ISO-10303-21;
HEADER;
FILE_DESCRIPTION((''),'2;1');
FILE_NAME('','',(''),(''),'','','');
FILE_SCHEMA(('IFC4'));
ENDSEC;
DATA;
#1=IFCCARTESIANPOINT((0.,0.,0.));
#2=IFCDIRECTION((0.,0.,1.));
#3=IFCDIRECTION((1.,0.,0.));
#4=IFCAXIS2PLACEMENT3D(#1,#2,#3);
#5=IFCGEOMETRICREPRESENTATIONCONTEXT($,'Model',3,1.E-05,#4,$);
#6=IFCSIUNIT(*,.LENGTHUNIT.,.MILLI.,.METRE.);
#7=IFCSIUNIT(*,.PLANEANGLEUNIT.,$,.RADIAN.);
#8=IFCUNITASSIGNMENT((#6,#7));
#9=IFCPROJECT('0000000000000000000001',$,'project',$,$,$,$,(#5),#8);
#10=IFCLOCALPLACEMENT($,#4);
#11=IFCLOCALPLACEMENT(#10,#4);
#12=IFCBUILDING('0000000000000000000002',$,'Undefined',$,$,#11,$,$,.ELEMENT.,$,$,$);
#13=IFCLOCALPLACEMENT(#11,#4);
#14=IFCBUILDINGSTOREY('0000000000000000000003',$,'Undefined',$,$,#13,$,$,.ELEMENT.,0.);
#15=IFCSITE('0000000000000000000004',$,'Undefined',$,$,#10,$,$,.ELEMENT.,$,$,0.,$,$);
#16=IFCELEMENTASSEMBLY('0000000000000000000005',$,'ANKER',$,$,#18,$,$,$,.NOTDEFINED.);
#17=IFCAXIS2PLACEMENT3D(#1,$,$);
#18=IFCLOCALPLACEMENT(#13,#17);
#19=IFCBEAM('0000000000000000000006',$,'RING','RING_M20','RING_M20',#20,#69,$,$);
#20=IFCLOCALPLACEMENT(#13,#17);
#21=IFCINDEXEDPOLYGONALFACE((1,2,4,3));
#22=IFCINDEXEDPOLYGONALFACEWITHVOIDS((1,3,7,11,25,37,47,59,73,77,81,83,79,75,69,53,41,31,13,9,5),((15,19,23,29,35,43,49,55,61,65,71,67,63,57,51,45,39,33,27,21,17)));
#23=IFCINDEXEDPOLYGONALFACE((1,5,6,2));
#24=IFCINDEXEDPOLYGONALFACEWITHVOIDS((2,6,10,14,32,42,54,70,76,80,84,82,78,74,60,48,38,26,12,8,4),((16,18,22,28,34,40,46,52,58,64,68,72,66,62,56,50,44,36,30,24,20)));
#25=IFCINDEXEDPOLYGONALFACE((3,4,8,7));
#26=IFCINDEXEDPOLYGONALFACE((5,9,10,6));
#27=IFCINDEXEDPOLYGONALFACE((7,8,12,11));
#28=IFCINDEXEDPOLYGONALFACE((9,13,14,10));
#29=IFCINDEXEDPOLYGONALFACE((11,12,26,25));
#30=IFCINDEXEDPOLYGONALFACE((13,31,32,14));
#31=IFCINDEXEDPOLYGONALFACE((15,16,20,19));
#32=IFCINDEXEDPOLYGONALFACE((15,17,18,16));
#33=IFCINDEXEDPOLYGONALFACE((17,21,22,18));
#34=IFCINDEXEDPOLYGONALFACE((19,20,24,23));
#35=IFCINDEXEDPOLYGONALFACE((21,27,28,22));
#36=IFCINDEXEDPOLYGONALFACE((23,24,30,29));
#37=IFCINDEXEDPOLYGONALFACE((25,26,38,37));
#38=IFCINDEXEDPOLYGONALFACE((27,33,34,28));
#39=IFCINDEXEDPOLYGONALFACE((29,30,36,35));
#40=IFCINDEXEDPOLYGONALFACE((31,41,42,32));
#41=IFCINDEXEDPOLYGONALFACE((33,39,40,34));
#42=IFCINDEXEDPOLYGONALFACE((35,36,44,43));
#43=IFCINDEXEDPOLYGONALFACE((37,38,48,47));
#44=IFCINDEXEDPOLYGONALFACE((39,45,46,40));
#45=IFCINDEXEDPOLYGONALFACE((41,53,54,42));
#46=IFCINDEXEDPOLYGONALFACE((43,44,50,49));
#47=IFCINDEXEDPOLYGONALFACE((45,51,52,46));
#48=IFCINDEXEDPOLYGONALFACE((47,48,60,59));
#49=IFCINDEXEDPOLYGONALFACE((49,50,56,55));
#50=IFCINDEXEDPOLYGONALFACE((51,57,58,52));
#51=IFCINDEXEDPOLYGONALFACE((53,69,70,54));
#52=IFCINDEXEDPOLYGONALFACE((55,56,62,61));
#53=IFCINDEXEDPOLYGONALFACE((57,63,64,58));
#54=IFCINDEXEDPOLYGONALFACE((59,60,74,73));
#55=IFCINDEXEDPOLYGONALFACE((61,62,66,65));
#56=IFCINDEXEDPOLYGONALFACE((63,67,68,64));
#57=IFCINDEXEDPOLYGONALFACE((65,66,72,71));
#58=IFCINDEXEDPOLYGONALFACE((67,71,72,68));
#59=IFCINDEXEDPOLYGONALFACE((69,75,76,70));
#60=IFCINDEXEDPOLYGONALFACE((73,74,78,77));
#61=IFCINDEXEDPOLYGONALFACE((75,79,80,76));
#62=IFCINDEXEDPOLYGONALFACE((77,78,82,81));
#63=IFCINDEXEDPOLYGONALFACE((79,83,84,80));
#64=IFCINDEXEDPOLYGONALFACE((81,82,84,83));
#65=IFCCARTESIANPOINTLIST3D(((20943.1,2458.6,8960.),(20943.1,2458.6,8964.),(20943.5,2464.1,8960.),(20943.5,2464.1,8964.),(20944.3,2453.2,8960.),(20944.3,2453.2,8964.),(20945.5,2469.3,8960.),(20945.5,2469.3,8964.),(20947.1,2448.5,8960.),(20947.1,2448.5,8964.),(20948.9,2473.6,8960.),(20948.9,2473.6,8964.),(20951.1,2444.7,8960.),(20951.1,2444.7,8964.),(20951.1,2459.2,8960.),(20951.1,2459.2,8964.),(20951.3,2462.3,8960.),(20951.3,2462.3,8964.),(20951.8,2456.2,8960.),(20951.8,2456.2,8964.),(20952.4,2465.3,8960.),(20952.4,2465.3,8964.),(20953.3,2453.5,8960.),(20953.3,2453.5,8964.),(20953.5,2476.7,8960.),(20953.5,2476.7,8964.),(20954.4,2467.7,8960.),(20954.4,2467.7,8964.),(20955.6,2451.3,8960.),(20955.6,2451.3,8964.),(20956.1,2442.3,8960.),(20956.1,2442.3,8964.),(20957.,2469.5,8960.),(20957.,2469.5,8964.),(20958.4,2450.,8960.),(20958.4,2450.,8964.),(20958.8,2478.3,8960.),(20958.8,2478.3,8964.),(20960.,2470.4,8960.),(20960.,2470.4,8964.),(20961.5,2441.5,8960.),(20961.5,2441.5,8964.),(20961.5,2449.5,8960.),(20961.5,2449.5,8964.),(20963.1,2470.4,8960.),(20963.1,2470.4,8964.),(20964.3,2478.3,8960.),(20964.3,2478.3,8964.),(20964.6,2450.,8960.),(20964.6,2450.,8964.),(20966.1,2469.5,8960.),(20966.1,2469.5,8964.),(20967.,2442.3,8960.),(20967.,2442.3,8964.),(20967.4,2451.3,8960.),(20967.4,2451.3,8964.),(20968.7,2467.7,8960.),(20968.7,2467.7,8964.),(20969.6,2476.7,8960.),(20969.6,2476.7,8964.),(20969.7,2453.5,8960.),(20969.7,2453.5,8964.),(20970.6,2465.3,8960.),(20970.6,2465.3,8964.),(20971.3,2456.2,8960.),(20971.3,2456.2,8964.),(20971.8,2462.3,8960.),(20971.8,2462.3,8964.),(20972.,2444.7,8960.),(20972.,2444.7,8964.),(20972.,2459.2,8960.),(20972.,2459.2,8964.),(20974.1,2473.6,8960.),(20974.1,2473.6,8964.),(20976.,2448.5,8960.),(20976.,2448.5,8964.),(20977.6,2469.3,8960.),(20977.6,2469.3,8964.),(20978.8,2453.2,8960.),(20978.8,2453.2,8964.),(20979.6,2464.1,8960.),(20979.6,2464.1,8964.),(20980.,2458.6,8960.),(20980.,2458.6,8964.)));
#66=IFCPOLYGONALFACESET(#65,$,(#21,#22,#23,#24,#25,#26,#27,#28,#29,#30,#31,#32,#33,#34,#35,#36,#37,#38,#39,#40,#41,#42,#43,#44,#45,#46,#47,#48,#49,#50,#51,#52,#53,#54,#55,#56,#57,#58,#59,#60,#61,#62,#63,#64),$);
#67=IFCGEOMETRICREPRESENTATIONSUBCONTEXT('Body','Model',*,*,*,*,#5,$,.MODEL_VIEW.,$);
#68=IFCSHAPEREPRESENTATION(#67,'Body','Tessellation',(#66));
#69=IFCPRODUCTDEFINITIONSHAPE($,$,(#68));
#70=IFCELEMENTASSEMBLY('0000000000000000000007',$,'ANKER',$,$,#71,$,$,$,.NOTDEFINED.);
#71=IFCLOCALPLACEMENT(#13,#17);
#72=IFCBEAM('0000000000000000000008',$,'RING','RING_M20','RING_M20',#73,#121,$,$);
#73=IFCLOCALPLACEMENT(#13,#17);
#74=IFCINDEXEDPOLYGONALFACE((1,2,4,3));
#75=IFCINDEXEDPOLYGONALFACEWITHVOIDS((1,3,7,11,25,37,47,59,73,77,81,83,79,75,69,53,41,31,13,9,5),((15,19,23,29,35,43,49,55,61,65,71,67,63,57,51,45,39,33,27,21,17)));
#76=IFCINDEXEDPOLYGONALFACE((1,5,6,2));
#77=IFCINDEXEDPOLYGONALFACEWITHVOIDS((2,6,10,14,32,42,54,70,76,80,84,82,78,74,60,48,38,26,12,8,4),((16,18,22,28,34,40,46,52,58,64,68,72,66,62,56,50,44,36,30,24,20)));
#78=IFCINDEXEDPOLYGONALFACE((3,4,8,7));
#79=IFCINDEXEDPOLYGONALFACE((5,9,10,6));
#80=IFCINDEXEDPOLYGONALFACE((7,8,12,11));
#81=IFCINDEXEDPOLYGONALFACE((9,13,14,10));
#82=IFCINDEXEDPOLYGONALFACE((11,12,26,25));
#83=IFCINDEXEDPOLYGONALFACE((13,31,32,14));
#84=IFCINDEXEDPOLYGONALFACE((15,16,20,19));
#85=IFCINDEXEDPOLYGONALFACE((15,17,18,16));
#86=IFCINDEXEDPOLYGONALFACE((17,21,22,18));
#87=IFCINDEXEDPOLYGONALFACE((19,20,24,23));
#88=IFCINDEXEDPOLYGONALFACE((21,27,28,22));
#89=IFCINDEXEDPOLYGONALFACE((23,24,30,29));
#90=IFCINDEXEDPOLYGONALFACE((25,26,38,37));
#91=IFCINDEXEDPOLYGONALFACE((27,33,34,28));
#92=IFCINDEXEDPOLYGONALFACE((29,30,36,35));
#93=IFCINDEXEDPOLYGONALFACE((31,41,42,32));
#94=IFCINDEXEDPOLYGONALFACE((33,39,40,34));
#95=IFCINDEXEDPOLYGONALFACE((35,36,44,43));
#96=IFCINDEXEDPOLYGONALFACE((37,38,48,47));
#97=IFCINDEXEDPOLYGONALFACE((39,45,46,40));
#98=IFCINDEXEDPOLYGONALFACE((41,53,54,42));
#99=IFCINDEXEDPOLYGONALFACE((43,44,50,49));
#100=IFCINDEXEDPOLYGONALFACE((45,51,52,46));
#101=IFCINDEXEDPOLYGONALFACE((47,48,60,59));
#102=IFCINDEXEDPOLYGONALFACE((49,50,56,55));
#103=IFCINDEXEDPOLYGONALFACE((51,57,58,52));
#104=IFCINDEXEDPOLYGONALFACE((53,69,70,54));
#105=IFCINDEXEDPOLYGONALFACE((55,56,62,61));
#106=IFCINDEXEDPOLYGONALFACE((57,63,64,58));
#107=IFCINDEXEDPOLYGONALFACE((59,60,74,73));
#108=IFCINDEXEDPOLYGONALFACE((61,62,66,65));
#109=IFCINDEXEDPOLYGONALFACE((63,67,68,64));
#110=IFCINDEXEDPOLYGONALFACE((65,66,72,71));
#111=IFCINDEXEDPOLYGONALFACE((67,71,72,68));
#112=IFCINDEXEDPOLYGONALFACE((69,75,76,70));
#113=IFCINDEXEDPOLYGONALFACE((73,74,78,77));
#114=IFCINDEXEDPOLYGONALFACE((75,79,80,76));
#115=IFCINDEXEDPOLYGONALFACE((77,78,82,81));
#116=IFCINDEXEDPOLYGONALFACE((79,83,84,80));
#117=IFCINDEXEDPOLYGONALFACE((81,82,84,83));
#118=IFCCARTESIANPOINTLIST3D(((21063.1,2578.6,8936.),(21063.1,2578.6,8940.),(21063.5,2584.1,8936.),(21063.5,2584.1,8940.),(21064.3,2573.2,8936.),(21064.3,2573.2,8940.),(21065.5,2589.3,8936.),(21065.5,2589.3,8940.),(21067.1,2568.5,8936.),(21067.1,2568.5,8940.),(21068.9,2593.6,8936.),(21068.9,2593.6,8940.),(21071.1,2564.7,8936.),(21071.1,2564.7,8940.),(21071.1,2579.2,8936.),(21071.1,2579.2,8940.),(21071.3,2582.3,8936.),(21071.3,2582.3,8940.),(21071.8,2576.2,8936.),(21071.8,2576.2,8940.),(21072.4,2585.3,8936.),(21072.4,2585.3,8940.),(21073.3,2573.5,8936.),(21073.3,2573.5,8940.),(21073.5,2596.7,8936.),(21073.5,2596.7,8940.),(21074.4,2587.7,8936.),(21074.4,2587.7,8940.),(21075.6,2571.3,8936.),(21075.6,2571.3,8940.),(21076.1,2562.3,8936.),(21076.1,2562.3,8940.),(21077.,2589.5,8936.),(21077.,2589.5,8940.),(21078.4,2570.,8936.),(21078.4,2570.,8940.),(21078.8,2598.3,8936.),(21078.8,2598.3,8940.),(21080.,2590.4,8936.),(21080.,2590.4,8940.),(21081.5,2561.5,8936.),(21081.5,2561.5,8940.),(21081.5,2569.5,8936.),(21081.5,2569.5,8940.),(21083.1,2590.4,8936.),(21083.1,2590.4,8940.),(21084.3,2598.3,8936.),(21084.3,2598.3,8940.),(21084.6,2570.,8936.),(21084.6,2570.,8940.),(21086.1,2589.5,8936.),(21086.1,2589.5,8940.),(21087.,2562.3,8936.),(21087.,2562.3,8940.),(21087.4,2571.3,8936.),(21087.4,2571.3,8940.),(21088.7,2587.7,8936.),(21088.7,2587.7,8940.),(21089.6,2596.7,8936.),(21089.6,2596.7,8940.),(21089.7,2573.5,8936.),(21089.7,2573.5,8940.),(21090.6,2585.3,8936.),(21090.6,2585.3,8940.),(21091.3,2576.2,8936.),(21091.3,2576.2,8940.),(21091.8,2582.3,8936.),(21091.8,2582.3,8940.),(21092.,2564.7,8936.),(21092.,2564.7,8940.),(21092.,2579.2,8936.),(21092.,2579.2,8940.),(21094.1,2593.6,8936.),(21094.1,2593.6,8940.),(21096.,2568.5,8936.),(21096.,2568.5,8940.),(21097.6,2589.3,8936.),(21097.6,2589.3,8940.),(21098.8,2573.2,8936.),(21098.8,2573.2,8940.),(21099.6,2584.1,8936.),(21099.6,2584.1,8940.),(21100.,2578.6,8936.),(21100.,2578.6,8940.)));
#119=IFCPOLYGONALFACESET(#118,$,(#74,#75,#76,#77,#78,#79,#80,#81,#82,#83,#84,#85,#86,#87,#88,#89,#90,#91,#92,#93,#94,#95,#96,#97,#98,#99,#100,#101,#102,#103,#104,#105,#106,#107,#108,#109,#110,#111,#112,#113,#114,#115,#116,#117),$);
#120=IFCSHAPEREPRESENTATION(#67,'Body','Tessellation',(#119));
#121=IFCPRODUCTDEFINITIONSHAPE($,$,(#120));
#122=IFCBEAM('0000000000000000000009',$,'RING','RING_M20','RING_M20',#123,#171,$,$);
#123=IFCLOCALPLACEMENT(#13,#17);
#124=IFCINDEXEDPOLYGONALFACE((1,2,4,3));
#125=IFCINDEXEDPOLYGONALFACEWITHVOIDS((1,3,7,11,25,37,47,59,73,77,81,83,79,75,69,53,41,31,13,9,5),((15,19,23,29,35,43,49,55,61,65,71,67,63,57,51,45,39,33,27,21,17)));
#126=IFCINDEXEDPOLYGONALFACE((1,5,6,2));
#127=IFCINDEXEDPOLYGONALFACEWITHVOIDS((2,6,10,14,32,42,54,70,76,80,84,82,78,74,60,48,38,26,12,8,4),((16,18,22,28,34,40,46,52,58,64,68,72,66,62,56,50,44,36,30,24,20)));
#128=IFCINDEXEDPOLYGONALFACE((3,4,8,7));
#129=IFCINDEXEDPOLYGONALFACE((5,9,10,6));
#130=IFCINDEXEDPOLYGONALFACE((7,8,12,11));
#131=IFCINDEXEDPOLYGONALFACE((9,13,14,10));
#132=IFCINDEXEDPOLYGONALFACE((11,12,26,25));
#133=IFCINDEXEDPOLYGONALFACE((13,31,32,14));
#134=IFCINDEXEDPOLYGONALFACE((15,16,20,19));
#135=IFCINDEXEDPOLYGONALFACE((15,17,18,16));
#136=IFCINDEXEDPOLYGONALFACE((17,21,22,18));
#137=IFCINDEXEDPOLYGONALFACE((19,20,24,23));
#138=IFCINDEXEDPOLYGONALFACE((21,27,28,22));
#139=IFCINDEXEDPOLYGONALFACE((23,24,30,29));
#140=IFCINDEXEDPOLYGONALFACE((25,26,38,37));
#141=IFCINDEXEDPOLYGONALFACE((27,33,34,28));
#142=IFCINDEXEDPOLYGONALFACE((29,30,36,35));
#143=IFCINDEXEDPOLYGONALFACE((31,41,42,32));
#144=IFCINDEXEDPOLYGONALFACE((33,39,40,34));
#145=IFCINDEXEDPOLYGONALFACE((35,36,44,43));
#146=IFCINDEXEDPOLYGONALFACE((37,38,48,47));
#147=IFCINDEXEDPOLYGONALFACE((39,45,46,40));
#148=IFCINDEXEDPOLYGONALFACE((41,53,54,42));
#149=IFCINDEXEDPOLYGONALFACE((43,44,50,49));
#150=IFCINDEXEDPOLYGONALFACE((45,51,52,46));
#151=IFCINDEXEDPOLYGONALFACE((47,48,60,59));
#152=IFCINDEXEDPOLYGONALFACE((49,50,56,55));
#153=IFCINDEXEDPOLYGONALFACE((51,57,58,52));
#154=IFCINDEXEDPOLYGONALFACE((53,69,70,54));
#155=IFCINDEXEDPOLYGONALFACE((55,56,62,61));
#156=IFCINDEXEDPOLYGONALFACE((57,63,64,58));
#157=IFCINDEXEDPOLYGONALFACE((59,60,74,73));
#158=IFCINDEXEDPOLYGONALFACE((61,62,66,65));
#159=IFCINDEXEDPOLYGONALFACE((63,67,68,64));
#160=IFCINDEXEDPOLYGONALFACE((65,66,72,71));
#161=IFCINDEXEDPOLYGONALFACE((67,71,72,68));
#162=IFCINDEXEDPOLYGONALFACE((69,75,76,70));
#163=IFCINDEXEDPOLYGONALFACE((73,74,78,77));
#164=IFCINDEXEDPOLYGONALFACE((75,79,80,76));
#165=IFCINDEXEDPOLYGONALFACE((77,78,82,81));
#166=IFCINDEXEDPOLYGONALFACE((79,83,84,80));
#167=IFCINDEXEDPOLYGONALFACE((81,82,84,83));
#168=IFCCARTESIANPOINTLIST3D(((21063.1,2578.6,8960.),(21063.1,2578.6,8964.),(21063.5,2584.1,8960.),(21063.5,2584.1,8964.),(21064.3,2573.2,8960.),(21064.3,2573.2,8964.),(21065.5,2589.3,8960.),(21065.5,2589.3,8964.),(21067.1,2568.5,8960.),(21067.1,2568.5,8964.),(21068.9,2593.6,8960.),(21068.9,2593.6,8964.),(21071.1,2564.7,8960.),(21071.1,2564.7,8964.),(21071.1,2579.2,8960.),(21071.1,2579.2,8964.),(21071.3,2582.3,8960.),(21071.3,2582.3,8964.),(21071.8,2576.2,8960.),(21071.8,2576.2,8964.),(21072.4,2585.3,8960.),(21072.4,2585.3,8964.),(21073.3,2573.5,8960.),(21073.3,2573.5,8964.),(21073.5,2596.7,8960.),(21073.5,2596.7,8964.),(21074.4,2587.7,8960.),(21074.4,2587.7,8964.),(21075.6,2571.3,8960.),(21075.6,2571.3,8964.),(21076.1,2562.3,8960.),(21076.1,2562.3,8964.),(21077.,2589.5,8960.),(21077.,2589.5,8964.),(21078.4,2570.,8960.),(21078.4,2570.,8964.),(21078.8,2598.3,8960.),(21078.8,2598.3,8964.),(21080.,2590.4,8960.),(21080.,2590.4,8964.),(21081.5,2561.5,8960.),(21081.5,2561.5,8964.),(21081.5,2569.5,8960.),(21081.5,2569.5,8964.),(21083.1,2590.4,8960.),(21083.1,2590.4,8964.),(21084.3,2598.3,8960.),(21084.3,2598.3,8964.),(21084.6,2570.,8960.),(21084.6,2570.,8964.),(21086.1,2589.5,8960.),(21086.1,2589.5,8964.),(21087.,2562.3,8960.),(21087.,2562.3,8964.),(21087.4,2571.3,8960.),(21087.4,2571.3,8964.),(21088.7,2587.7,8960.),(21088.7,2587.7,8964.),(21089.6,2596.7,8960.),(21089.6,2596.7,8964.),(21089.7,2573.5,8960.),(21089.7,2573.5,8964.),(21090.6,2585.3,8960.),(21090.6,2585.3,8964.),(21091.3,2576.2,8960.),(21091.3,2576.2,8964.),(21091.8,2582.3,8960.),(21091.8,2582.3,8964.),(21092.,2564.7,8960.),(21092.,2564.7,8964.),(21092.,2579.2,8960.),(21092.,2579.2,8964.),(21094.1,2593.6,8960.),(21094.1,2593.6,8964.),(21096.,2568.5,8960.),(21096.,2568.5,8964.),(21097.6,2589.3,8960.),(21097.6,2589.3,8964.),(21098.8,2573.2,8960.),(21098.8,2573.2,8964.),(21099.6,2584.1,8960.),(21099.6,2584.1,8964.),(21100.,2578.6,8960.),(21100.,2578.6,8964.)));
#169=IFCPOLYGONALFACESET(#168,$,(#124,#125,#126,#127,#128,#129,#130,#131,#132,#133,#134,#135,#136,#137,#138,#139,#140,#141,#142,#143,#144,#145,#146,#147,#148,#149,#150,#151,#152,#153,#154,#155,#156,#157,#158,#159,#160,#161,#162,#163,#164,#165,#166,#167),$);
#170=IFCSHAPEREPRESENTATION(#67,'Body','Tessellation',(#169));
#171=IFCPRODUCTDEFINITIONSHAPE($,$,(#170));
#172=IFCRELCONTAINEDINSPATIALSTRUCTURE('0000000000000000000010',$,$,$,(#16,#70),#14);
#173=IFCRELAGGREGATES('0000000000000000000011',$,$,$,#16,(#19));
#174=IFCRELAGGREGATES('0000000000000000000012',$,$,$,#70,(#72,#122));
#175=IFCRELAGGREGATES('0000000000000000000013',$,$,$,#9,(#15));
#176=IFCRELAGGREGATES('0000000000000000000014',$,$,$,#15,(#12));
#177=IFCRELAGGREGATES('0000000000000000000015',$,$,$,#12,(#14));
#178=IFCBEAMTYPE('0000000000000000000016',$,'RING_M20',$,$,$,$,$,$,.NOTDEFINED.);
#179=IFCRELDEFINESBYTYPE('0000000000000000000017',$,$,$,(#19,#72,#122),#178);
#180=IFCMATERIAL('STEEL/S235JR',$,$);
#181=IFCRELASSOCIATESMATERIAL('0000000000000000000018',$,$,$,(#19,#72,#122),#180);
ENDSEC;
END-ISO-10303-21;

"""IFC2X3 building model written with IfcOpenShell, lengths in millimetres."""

from ifc_helpers import new_model, si_unit, frame, origin_with_axes, origin_2d_with_axis, place, context, subcontext, project, spatial, hollow_circle, extrude, material, type_object, element, aggregate, save


model = new_model("IFC2X3")

# Units and contexts
model_context = context("Model", 3, precision=1e-05, world=origin_with_axes())
body_context = subcontext(model_context, "Body", "Model", "MODEL_VIEW")
ifc_project = project(units=[si_unit("LENGTHUNIT", "METRE", prefix="MILLI"), si_unit("PLANEANGLEUNIT", "RADIAN")], contexts=[model_context])

# Site, building, storey
site_placement = place(None, origin_with_axes())
site = spatial("IfcSite", under=ifc_project, at=site_placement, Name="Undefined", CompositionType="ELEMENT", RefElevation=0.0)
building_placement = place(site_placement, origin_with_axes())
building = spatial("IfcBuilding", under=site, at=building_placement, Name="Undefined", CompositionType="ELEMENT")
storey_placement = place(building_placement, origin_with_axes())
storey = spatial("IfcBuildingStorey", under=building, at=storey_placement, Name="Undefined", CompositionType="ELEMENT", Elevation=0.0)

# Shared definitions
ifc_material = material(Name="STEEL/S235JR")

# Element assemblies, beams
beam_type_1 = type_object("IfcBeamType", Name="RING_M20", PredefinedType="NOTDEFINED")
assembly_1_placement = place(storey_placement, frame((20961.5, 2460.0, 9010.0), z_axis=(0.0, 1.0, 0.0), x_axis=(0.0, 0.0, -1.0)))
assembly_1 = element("IfcElementAssembly", 1, at=assembly_1_placement, inside=storey, Name="ANKER", PredefinedType="NOTDEFINED")
beam_1_placement = place(storey_placement, frame((20961.5, 2460.0, 8964.0), z_axis=(1.0, 0.0, 0.0), x_axis=(0.0, 0.0, -1.0)))
beam_1 = element("IfcBeam", 2, at=beam_1_placement, type_object=beam_type_1, material=ifc_material, Name="RING", Description="RING_M20", ObjectType="RING_M20", context=body_context, shape_type="SweptSolid", body=[
    extrude(hollow_circle(Radius=18.5, WallThickness=8.0, at=origin_2d_with_axis()), frame((4.0, 0.0, 0.0), z_axis=(-1.0, 0.0, 0.0), x_axis=(0.0, -1.0, 0.0)), (0.0, 0.0, 1.0), 4.0),
])
aggregate(assembly_1, [beam_1])
assembly_2_placement = place(storey_placement, frame((21081.5, 2580.0, 9010.0), z_axis=(0.0, 1.0, 0.0), x_axis=(0.0, 0.0, -1.0)))
assembly_2 = element("IfcElementAssembly", 3, at=assembly_2_placement, inside=storey, Name="ANKER", PredefinedType="NOTDEFINED")
beam_2_placement = place(storey_placement, frame((21081.5, 2580.0, 8940.0), z_axis=(1.0, 0.0, 0.0), x_axis=(0.0, 0.0, -1.0)))
beam_2 = element("IfcBeam", 4, at=beam_2_placement, type_object=beam_type_1, material=ifc_material, Name="RING", Description="RING_M20", ObjectType="RING_M20", context=body_context, shape_type="SweptSolid", body=[
    extrude(hollow_circle(Radius=18.5, WallThickness=8.0, at=origin_2d_with_axis()), frame((4.0, 0.0, 0.0), z_axis=(-1.0, 0.0, 0.0), x_axis=(0.0, -1.0, 0.0)), (0.0, 0.0, 1.0), 4.0),
])
beam_3_placement = place(storey_placement, frame((21081.5, 2580.0, 8964.0), z_axis=(1.0, 0.0, 0.0), x_axis=(0.0, 0.0, -1.0)))
beam_3 = element("IfcBeam", 5, at=beam_3_placement, type_object=beam_type_1, material=ifc_material, Name="RING", Description="RING_M20", ObjectType="RING_M20", context=body_context, shape_type="SweptSolid", body=[
    extrude(hollow_circle(Radius=18.5, WallThickness=8.0, at=origin_2d_with_axis()), frame((4.0, 0.0, 0.0), z_axis=(-1.0, 0.0, 0.0), x_axis=(0.0, -1.0, 0.0)), (0.0, 0.0, 1.0), 4.0),
])
aggregate(assembly_2, [beam_2, beam_3])

save(model, "model.ifc")
